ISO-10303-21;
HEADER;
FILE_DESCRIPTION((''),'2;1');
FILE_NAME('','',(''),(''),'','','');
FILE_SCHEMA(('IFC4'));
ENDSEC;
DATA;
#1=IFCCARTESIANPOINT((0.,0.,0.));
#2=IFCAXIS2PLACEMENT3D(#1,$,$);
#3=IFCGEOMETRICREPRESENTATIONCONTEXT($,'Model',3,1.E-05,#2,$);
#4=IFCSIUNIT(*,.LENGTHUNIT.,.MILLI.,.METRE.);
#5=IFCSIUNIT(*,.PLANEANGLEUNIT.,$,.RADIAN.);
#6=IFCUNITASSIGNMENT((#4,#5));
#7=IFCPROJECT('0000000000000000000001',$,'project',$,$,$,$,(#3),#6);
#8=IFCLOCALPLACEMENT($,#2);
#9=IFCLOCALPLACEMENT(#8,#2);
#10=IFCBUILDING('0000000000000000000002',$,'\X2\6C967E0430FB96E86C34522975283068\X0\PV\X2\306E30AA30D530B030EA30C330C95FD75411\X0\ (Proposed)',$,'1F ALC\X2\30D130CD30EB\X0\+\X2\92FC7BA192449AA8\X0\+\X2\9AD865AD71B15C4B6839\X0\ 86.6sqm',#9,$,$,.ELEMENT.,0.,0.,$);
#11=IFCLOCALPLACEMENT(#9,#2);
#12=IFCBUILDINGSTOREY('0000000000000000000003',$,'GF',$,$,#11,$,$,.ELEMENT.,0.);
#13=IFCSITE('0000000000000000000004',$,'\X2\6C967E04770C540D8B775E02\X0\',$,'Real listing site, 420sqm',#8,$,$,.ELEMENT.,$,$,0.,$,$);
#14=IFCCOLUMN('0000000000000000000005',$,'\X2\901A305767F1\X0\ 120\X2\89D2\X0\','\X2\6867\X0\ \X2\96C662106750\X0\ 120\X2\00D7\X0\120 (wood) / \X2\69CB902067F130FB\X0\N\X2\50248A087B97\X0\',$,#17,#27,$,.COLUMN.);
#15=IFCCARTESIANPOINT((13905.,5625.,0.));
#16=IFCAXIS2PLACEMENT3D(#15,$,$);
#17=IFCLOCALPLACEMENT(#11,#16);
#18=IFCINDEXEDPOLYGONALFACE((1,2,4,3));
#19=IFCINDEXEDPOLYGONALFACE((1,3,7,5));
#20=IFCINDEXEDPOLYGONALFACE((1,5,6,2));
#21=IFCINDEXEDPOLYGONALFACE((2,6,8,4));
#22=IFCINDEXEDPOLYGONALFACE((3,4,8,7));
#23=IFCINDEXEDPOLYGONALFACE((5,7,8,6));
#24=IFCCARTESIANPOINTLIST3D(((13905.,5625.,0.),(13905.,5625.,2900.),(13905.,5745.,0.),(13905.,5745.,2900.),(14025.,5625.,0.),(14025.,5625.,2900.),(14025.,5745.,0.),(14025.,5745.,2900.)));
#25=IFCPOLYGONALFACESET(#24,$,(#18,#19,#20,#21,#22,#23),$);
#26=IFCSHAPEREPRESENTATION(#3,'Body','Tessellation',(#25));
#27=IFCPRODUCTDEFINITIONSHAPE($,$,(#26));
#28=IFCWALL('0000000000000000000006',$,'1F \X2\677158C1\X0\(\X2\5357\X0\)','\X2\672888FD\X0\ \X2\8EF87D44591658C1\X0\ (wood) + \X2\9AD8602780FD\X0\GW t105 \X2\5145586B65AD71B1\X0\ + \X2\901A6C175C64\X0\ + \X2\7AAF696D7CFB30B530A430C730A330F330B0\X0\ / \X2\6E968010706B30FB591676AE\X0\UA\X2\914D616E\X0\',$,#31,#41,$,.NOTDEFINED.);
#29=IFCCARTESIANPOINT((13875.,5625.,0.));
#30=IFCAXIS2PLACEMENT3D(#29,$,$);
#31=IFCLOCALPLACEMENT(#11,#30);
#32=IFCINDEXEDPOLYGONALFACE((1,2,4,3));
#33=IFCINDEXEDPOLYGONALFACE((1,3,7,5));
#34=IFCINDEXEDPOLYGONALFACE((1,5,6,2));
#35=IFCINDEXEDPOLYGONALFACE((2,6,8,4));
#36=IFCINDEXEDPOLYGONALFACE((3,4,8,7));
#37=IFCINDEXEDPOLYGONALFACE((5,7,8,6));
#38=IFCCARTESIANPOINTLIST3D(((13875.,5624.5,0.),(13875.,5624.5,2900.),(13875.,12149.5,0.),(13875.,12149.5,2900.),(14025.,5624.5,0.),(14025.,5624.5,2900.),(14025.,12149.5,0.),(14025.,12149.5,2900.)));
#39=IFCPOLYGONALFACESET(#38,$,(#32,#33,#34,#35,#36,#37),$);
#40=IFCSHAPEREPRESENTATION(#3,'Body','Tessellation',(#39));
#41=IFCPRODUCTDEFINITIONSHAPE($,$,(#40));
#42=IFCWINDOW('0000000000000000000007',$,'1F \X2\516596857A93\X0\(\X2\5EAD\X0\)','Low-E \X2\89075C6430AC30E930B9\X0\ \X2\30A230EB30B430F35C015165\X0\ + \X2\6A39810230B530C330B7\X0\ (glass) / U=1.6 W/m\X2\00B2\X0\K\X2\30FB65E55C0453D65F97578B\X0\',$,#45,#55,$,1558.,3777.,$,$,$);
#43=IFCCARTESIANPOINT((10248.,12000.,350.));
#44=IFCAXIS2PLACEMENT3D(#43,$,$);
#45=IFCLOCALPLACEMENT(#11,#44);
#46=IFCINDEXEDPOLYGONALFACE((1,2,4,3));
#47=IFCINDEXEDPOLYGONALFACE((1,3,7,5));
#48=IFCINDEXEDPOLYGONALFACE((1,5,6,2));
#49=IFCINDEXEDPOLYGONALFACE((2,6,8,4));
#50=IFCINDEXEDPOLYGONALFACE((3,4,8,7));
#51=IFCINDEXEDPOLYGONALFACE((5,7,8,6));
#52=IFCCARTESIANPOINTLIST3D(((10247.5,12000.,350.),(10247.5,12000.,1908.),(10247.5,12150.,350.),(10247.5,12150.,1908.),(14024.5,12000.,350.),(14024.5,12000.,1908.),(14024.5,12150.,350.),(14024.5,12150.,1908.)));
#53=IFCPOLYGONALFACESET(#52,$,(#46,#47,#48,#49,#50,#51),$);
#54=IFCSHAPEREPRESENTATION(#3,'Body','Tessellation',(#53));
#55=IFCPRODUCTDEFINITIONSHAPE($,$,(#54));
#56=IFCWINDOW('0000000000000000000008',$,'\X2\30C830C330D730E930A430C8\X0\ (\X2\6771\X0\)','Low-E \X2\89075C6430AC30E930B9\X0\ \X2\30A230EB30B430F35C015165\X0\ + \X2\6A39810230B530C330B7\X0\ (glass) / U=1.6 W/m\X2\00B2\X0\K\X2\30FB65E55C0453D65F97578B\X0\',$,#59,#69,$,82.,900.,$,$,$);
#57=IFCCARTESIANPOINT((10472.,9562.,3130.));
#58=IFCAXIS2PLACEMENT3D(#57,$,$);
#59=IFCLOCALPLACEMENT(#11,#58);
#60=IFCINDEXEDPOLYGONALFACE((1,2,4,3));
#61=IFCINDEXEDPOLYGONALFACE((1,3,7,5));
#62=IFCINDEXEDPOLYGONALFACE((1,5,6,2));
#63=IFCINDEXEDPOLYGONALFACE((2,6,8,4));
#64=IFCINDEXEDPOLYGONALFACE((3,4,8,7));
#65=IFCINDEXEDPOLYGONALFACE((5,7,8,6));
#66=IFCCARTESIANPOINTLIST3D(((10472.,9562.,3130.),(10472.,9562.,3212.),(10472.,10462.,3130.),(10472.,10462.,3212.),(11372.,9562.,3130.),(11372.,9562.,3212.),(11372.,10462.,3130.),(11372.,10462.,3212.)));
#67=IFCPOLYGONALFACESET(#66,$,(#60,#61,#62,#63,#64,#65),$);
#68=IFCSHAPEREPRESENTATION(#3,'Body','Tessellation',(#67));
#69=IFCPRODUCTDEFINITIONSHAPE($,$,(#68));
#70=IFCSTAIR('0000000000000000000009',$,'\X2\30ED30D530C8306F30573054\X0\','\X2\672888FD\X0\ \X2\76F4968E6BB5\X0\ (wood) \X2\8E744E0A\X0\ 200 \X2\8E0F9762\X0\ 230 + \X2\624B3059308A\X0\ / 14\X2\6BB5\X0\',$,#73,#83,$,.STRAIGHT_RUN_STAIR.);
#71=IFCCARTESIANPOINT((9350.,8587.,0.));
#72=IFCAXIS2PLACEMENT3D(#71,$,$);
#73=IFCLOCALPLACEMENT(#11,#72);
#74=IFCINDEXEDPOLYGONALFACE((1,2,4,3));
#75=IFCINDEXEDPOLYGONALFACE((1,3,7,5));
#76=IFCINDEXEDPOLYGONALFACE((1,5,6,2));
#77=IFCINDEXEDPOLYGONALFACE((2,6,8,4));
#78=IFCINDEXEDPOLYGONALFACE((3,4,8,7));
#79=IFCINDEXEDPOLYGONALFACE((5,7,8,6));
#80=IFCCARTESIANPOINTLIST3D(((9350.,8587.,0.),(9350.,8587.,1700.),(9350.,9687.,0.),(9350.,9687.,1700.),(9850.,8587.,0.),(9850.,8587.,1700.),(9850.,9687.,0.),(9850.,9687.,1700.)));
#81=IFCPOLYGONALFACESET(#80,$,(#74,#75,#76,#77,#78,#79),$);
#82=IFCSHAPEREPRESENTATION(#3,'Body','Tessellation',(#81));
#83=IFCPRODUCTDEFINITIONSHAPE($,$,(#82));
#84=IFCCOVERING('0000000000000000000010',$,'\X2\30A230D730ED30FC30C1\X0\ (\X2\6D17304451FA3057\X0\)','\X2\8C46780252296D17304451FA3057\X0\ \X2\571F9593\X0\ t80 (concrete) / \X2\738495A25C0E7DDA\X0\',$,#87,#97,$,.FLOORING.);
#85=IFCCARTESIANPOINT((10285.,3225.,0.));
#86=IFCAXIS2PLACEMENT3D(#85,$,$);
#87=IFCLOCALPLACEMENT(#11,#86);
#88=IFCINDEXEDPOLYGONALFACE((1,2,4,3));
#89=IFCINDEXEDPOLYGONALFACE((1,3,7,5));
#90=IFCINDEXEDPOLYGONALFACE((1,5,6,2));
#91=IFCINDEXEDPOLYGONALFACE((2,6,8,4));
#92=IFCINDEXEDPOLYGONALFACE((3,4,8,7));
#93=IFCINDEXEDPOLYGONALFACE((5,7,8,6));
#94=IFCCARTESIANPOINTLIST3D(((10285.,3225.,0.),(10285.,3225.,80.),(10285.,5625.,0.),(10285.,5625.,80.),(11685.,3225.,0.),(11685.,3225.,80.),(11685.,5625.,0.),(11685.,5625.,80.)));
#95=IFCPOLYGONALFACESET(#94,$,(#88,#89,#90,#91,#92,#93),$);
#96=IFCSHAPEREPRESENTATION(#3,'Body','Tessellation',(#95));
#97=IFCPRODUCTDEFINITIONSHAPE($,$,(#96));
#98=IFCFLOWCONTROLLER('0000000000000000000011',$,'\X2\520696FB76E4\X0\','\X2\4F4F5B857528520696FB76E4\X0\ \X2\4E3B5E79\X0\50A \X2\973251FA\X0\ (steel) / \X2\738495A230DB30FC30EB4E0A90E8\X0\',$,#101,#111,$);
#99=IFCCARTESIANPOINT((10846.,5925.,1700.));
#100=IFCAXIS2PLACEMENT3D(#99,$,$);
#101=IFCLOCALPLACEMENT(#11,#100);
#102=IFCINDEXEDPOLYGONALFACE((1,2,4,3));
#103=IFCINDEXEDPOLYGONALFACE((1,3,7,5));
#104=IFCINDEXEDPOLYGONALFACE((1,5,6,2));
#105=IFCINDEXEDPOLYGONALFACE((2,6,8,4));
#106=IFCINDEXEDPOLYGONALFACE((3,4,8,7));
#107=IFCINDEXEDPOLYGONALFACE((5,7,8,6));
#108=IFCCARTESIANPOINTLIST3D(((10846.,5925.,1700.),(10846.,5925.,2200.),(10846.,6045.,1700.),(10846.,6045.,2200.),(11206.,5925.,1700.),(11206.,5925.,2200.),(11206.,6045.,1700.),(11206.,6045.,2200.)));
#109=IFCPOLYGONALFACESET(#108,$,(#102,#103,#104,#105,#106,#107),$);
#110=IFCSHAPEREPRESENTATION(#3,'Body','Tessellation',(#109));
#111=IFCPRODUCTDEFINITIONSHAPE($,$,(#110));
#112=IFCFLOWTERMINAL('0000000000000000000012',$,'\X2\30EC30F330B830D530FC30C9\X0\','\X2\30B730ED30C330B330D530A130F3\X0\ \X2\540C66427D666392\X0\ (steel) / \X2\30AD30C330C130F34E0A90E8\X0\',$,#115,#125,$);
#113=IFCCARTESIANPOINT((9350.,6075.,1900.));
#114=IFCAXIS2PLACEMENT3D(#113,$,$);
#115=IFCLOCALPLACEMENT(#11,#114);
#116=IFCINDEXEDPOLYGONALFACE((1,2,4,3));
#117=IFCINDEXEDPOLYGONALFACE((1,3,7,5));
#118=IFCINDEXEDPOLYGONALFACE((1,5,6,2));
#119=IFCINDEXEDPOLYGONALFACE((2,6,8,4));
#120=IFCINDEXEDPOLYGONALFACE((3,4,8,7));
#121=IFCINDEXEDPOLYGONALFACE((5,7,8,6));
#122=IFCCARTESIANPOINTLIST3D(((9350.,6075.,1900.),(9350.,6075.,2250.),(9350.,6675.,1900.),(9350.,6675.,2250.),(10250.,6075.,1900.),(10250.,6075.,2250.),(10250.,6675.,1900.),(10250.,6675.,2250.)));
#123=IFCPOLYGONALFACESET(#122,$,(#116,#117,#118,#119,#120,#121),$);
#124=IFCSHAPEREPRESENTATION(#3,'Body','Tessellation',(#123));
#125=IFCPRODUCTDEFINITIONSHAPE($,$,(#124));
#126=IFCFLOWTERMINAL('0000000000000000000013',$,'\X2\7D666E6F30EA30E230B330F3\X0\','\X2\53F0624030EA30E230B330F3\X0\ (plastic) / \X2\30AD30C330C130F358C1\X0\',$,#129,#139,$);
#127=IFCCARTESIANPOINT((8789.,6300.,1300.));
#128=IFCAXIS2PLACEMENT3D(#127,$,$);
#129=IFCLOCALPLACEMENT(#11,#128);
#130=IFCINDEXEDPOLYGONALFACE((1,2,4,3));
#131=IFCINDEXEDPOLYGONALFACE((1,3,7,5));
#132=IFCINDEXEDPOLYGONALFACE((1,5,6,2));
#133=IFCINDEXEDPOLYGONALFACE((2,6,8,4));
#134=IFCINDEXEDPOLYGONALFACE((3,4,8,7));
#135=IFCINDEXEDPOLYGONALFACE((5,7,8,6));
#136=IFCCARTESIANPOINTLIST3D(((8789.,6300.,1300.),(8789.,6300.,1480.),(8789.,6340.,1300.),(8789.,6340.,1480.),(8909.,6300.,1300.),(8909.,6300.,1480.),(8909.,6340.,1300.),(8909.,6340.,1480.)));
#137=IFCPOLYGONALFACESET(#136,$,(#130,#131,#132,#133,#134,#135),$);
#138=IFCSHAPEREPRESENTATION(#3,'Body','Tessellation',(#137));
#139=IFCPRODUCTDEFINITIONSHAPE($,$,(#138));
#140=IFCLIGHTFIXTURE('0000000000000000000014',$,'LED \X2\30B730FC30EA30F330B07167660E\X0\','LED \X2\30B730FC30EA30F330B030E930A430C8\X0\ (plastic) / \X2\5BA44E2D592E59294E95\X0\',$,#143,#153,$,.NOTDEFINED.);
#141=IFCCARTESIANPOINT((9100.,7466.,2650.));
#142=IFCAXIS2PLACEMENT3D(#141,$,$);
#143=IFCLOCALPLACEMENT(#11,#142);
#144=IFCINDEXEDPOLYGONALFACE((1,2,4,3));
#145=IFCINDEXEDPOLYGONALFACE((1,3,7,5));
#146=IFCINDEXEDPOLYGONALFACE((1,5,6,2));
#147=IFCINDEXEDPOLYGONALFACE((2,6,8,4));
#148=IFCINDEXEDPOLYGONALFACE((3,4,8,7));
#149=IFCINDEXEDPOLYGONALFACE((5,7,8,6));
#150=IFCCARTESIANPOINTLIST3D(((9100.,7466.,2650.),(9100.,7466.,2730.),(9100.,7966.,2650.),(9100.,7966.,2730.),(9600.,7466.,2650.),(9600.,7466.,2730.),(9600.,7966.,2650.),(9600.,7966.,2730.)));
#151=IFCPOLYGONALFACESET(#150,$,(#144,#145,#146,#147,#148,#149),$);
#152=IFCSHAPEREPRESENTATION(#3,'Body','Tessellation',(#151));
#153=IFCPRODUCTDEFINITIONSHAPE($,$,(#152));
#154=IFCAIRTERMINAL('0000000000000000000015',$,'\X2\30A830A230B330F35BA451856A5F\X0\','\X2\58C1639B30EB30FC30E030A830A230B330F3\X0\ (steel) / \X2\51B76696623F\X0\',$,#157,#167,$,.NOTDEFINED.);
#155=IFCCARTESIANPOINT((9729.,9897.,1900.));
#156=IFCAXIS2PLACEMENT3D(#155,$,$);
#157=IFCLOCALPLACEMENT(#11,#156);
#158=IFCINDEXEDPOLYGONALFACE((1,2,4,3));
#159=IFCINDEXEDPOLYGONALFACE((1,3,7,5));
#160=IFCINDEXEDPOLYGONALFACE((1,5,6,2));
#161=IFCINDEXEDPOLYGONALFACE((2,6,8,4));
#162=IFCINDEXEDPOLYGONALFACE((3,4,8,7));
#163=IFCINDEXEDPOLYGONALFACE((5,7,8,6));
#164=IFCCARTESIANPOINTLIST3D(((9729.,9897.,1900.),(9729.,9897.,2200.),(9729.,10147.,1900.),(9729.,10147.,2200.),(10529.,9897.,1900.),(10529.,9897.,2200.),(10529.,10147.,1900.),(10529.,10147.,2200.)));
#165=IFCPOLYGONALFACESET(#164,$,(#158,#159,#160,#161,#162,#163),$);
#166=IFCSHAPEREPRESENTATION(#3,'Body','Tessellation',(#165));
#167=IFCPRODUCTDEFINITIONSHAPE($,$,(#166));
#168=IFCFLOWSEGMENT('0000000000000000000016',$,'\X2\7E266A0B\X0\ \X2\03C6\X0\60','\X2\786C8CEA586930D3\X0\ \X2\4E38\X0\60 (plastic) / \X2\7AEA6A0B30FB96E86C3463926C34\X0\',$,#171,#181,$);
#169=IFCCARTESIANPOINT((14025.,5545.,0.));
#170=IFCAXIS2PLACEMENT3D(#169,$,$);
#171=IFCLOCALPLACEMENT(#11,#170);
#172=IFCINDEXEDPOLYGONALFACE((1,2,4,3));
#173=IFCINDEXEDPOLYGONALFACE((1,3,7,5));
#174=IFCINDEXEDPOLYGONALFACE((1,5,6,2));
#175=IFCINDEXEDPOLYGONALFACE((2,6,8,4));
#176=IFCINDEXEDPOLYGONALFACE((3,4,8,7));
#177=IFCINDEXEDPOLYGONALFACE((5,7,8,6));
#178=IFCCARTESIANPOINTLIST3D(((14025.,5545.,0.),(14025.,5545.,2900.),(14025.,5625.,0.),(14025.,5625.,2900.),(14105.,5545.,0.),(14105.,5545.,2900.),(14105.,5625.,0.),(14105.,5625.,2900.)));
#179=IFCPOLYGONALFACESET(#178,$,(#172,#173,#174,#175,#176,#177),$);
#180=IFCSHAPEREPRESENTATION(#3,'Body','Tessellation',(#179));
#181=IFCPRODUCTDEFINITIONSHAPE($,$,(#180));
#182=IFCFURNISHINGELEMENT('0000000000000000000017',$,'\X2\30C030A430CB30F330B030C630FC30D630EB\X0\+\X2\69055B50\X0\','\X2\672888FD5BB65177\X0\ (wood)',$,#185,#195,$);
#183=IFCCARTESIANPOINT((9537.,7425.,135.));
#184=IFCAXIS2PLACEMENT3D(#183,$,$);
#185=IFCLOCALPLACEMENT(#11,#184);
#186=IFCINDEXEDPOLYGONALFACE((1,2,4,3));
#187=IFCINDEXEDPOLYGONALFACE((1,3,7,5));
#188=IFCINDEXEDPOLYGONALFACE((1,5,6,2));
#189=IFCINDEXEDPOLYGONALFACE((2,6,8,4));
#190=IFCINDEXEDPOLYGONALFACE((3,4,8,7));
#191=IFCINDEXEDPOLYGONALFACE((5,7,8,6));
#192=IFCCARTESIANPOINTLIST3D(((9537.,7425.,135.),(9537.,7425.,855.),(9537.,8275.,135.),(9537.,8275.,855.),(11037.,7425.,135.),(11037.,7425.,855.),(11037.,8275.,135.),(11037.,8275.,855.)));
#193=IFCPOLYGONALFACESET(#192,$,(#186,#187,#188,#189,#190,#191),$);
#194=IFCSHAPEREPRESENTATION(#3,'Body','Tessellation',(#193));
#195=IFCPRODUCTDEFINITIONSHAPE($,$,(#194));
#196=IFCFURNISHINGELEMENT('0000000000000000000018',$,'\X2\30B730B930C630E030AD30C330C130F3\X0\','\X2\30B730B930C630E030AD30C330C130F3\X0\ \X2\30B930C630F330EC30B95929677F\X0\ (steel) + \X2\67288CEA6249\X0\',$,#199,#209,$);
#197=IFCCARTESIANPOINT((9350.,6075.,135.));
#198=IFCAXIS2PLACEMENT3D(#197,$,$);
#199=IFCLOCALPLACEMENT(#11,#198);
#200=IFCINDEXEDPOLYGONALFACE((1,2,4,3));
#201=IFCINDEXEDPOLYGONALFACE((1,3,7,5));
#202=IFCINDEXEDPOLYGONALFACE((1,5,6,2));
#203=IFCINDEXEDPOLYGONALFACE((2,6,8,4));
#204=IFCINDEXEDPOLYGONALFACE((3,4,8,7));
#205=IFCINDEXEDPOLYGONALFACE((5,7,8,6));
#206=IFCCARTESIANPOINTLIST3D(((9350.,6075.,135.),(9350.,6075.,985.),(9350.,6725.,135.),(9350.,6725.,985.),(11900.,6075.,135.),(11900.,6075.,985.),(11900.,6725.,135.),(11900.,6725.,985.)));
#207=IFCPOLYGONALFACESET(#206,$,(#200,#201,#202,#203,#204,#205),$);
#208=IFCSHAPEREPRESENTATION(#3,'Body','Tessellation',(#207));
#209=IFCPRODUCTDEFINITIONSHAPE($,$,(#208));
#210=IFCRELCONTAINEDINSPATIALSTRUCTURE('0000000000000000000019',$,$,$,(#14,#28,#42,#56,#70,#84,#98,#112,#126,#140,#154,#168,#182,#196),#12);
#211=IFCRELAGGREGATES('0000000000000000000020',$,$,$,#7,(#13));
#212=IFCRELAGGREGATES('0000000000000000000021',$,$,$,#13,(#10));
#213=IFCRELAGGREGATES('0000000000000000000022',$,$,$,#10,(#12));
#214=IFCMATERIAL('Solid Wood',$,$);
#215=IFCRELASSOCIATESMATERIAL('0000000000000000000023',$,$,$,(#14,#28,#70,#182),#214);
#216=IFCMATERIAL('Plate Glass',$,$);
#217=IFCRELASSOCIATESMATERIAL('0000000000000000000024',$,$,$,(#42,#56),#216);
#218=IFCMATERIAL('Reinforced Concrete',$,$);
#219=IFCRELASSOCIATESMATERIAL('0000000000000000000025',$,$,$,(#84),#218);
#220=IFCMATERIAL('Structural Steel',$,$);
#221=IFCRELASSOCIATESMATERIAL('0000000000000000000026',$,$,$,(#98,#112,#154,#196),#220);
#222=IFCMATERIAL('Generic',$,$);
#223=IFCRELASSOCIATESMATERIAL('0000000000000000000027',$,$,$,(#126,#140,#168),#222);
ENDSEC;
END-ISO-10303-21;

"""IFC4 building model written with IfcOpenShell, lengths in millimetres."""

from ifc_helpers import new_model, si_unit, frame, frame_2d, origin, place, context, project, spatial, rectangle, extrude, material, element, fill, save


model = new_model("IFC4")

# Units and contexts
model_context = context("Model", 3, precision=1e-05, world=origin())
ifc_project = project(units=[si_unit("LENGTHUNIT", "METRE", prefix="MILLI"), si_unit("PLANEANGLEUNIT", "RADIAN")], contexts=[model_context])

# Site, building, storey
site_placement = place(None, origin())
site = spatial("IfcSite", under=ifc_project, at=site_placement, Name="沖縄県名護市", ObjectType="Real listing site, 420sqm", CompositionType="ELEMENT", RefElevation=0.0)
building_placement = place(site_placement, origin())
building = spatial("IfcBuilding", under=site, at=building_placement, Name="沖縄・雨水利用とPVのオフグリッド志向 (Proposed)", ObjectType="1F ALCパネル+鋼管鉄骨+高断熱屋根 86.6sqm", CompositionType="ELEMENT", ElevationOfRefHeight=0.0, ElevationOfTerrain=0.0)
storey_placement = place(building_placement, origin())
storey = spatial("IfcBuildingStorey", under=building, at=storey_placement, Name="GF", CompositionType="ELEMENT", Elevation=0.0)

# Column
ifc_material_1 = material(Name="Solid Wood")
column_1_placement = place(storey_placement, frame((13905.0, 5625.0, 0.0)))
element("IfcColumn", 1, at=column_1_placement, inside=storey, material=ifc_material_1, Name="通し柱 120角", Description="桧 集成材 120×120 (wood) / 構造柱・N値計算", PredefinedType="COLUMN", context=model_context, shape_type="SweptSolid", body=[
    extrude(rectangle(XDim=120.0, YDim=120.0, at=frame_2d((60.0, 60.0))), frame((13905.0, 5625.0, 0.0)), (0.0, 0.0, 1.0), 2900.0),
])

# Wall, opening, window
wall_1_placement = place(storey_placement, frame((13875.0, 5625.0, 0.0)))
wall_1 = element("IfcWall", 2, at=wall_1_placement, inside=storey, material=ifc_material_1, Name="1F 東壁(南)", Description="木製 軸組外壁 (wood) + 高性能GW t105 充填断熱 + 通気層 + 窯業系サイディング / 準耐火・外皮UA配慮", PredefinedType="NOTDEFINED", context=model_context, shape_type="SweptSolid", body=[
    extrude(rectangle(XDim=150.0, YDim=6525.0, at=frame_2d((75.0, 3262.0))), frame((13875.0, 5625.0, 0.0)), (0.0, 0.0, 1.0), 2900.0),
])
opening_1_placement = place(storey_placement, frame((10248.0, 12000.0, 350.0)))
opening_1 = element("IfcOpeningElement", 3, at=opening_1_placement, cuts=wall_1, PredefinedType="NOTDEFINED", context=model_context, shape_type="SweptSolid", body=[
    extrude(rectangle(XDim=3777.0, YDim=150.0, at=frame_2d((1888.0, 75.0))), frame((10248.0, 12000.0, 350.0)), (0.0, 0.0, 1.0), 1558.0),
])
ifc_material_2 = material(Name="Plate Glass")
window_1_placement = place(storey_placement, frame((10248.0, 12000.0, 350.0)))
window_1 = element("IfcWindow", 4, at=window_1_placement, inside=storey, material=ifc_material_2, Name="1F 入隅窓(庭)", Description="Low-E 複層ガラス アルゴン封入 + 樹脂サッシ (glass) / U=1.6 W/m²K・日射取得型", OverallHeight=1558.0, OverallWidth=3777.0, context=model_context, shape_type="SweptSolid", body=[
    extrude(rectangle(XDim=3777.0, YDim=150.0, at=frame_2d((1888.0, 75.0))), frame((10248.0, 12000.0, 350.0)), (0.0, 0.0, 1.0), 1558.0),
])
fill(opening_1, window_1)

# Window
window_2_placement = place(storey_placement, frame((10472.0, 9562.0, 3130.0)))
element("IfcWindow", 5, at=window_2_placement, inside=storey, material=ifc_material_2, Name="トップライト (東)", Description="Low-E 複層ガラス アルゴン封入 + 樹脂サッシ (glass) / U=1.6 W/m²K・日射取得型", OverallHeight=82.0, OverallWidth=900.0, context=model_context, shape_type="SweptSolid", body=[
    extrude(rectangle(XDim=900.0, YDim=900.0, at=frame_2d((450.0, 450.0))), frame((10472.0, 9562.0, 3130.0)), (0.0, 0.0, 1.0), 82.0),
])

# Stair
stair_placement = place(storey_placement, frame((9350.0, 8587.0, 0.0)))
element("IfcStair", 6, at=stair_placement, inside=storey, material=ifc_material_1, Name="ロフトはしご", Description="木製 直階段 (wood) 蹴上 200 踏面 230 + 手すり / 14段", PredefinedType="STRAIGHT_RUN_STAIR", context=model_context, shape_type="SweptSolid", body=[
    extrude(rectangle(XDim=500.0, YDim=1100.0, at=frame_2d((250.0, 550.0))), frame((9350.0, 8587.0, 0.0)), (0.0, 0.0, 1.0), 1700.0),
])

# Covering
ifc_material_3 = material(Name="Reinforced Concrete")
covering_placement = place(storey_placement, frame((10285.0, 3225.0, 0.0)))
element("IfcCovering", 7, at=covering_placement, inside=storey, material=ifc_material_3, Name="アプローチ (洗い出し)", Description="豆砂利洗い出し 土間 t80 (concrete) / 玄関導線", PredefinedType="FLOORING", context=model_context, shape_type="SweptSolid", body=[
    extrude(rectangle(XDim=1400.0, YDim=2400.0, at=frame_2d((700.0, 1200.0))), frame((10285.0, 3225.0, 0.0)), (0.0, 0.0, 1.0), 80.0),
])

# Flow controller
ifc_material_4 = material(Name="Structural Steel")
flow_controller_placement = place(storey_placement, frame((10846.0, 5925.0, 1700.0)))
element("IfcFlowController", 8, at=flow_controller_placement, inside=storey, material=ifc_material_4, Name="分電盤", Description="住宅用分電盤 主幹50A 露出 (steel) / 玄関ホール上部", context=model_context, shape_type="SweptSolid", body=[
    extrude(rectangle(XDim=360.0, YDim=120.0, at=frame_2d((180.0, 60.0))), frame((10846.0, 5925.0, 1700.0)), (0.0, 0.0, 1.0), 500.0),
])

# Flow terminals
flow_terminal_1_placement = place(storey_placement, frame((9350.0, 6075.0, 1900.0)))
element("IfcFlowTerminal", 9, at=flow_terminal_1_placement, inside=storey, material=ifc_material_4, Name="レンジフード", Description="シロッコファン 同時給排 (steel) / キッチン上部", context=model_context, shape_type="SweptSolid", body=[
    extrude(rectangle(XDim=900.0, YDim=600.0, at=frame_2d((450.0, 300.0))), frame((9350.0, 6075.0, 1900.0)), (0.0, 0.0, 1.0), 350.0),
])
ifc_material_5 = material(Name="Generic")
flow_terminal_2_placement = place(storey_placement, frame((8789.0, 6300.0, 1300.0)))
element("IfcFlowTerminal", 10, at=flow_terminal_2_placement, inside=storey, material=ifc_material_5, Name="給湯リモコン", Description="台所リモコン (plastic) / キッチン壁", context=model_context, shape_type="SweptSolid", body=[
    extrude(rectangle(XDim=120.0, YDim=40.0, at=frame_2d((60.0, 20.0))), frame((8789.0, 6300.0, 1300.0)), (0.0, 0.0, 1.0), 180.0),
])

# Light fixture
light_fixture_placement = place(storey_placement, frame((9100.0, 7466.0, 2650.0)))
element("IfcLightFixture", 11, at=light_fixture_placement, inside=storey, material=ifc_material_5, Name="LED シーリング照明", Description="LED シーリングライト (plastic) / 室中央天井", PredefinedType="NOTDEFINED", context=model_context, shape_type="SweptSolid", body=[
    extrude(rectangle(XDim=500.0, YDim=500.0, at=frame_2d((250.0, 250.0))), frame((9100.0, 7466.0, 2650.0)), (0.0, 0.0, 1.0), 80.0),
])

# Air terminal
air_terminal_placement = place(storey_placement, frame((9729.0, 9897.0, 1900.0)))
element("IfcAirTerminal", 12, at=air_terminal_placement, inside=storey, material=ifc_material_4, Name="エアコン室内機", Description="壁掛ルームエアコン (steel) / 冷暖房", PredefinedType="NOTDEFINED", context=model_context, shape_type="SweptSolid", body=[
    extrude(rectangle(XDim=800.0, YDim=250.0, at=frame_2d((400.0, 125.0))), frame((9729.0, 9897.0, 1900.0)), (0.0, 0.0, 1.0), 300.0),
])

# Flow segment
flow_segment_placement = place(storey_placement, frame((14025.0, 5545.0, 0.0)))
element("IfcFlowSegment", 13, at=flow_segment_placement, inside=storey, material=ifc_material_5, Name="縦樋 φ60", Description="硬質塩ビ 丸60 (plastic) / 竪樋・雨水排水", context=model_context, shape_type="SweptSolid", body=[
    extrude(rectangle(XDim=80.0, YDim=80.0, at=frame_2d((40.0, 40.0))), frame((14025.0, 5545.0, 0.0)), (0.0, 0.0, 1.0), 2900.0),
])

# Furnishing elements
furnishing_1_placement = place(storey_placement, frame((9537.0, 7425.0, 135.0)))
element("IfcFurnishingElement", 14, at=furnishing_1_placement, inside=storey, material=ifc_material_1, Name="ダイニングテーブル+椅子", Description="木製家具 (wood)", context=model_context, shape_type="SweptSolid", body=[
    extrude(rectangle(XDim=1500.0, YDim=850.0, at=frame_2d((750.0, 425.0))), frame((9537.0, 7425.0, 135.0)), (0.0, 0.0, 1.0), 720.0),
])
furnishing_2_placement = place(storey_placement, frame((9350.0, 6075.0, 135.0)))
element("IfcFurnishingElement", 15, at=furnishing_2_placement, inside=storey, material=ifc_material_4, Name="システムキッチン", Description="システムキッチン ステンレス天板 (steel) + 木質扉", context=model_context, shape_type="SweptSolid", body=[
    extrude(rectangle(XDim=2550.0, YDim=650.0, at=frame_2d((1275.0, 325.0))), frame((9350.0, 6075.0, 135.0)), (0.0, 0.0, 1.0), 850.0),
])

save(model, "model.ifc")
